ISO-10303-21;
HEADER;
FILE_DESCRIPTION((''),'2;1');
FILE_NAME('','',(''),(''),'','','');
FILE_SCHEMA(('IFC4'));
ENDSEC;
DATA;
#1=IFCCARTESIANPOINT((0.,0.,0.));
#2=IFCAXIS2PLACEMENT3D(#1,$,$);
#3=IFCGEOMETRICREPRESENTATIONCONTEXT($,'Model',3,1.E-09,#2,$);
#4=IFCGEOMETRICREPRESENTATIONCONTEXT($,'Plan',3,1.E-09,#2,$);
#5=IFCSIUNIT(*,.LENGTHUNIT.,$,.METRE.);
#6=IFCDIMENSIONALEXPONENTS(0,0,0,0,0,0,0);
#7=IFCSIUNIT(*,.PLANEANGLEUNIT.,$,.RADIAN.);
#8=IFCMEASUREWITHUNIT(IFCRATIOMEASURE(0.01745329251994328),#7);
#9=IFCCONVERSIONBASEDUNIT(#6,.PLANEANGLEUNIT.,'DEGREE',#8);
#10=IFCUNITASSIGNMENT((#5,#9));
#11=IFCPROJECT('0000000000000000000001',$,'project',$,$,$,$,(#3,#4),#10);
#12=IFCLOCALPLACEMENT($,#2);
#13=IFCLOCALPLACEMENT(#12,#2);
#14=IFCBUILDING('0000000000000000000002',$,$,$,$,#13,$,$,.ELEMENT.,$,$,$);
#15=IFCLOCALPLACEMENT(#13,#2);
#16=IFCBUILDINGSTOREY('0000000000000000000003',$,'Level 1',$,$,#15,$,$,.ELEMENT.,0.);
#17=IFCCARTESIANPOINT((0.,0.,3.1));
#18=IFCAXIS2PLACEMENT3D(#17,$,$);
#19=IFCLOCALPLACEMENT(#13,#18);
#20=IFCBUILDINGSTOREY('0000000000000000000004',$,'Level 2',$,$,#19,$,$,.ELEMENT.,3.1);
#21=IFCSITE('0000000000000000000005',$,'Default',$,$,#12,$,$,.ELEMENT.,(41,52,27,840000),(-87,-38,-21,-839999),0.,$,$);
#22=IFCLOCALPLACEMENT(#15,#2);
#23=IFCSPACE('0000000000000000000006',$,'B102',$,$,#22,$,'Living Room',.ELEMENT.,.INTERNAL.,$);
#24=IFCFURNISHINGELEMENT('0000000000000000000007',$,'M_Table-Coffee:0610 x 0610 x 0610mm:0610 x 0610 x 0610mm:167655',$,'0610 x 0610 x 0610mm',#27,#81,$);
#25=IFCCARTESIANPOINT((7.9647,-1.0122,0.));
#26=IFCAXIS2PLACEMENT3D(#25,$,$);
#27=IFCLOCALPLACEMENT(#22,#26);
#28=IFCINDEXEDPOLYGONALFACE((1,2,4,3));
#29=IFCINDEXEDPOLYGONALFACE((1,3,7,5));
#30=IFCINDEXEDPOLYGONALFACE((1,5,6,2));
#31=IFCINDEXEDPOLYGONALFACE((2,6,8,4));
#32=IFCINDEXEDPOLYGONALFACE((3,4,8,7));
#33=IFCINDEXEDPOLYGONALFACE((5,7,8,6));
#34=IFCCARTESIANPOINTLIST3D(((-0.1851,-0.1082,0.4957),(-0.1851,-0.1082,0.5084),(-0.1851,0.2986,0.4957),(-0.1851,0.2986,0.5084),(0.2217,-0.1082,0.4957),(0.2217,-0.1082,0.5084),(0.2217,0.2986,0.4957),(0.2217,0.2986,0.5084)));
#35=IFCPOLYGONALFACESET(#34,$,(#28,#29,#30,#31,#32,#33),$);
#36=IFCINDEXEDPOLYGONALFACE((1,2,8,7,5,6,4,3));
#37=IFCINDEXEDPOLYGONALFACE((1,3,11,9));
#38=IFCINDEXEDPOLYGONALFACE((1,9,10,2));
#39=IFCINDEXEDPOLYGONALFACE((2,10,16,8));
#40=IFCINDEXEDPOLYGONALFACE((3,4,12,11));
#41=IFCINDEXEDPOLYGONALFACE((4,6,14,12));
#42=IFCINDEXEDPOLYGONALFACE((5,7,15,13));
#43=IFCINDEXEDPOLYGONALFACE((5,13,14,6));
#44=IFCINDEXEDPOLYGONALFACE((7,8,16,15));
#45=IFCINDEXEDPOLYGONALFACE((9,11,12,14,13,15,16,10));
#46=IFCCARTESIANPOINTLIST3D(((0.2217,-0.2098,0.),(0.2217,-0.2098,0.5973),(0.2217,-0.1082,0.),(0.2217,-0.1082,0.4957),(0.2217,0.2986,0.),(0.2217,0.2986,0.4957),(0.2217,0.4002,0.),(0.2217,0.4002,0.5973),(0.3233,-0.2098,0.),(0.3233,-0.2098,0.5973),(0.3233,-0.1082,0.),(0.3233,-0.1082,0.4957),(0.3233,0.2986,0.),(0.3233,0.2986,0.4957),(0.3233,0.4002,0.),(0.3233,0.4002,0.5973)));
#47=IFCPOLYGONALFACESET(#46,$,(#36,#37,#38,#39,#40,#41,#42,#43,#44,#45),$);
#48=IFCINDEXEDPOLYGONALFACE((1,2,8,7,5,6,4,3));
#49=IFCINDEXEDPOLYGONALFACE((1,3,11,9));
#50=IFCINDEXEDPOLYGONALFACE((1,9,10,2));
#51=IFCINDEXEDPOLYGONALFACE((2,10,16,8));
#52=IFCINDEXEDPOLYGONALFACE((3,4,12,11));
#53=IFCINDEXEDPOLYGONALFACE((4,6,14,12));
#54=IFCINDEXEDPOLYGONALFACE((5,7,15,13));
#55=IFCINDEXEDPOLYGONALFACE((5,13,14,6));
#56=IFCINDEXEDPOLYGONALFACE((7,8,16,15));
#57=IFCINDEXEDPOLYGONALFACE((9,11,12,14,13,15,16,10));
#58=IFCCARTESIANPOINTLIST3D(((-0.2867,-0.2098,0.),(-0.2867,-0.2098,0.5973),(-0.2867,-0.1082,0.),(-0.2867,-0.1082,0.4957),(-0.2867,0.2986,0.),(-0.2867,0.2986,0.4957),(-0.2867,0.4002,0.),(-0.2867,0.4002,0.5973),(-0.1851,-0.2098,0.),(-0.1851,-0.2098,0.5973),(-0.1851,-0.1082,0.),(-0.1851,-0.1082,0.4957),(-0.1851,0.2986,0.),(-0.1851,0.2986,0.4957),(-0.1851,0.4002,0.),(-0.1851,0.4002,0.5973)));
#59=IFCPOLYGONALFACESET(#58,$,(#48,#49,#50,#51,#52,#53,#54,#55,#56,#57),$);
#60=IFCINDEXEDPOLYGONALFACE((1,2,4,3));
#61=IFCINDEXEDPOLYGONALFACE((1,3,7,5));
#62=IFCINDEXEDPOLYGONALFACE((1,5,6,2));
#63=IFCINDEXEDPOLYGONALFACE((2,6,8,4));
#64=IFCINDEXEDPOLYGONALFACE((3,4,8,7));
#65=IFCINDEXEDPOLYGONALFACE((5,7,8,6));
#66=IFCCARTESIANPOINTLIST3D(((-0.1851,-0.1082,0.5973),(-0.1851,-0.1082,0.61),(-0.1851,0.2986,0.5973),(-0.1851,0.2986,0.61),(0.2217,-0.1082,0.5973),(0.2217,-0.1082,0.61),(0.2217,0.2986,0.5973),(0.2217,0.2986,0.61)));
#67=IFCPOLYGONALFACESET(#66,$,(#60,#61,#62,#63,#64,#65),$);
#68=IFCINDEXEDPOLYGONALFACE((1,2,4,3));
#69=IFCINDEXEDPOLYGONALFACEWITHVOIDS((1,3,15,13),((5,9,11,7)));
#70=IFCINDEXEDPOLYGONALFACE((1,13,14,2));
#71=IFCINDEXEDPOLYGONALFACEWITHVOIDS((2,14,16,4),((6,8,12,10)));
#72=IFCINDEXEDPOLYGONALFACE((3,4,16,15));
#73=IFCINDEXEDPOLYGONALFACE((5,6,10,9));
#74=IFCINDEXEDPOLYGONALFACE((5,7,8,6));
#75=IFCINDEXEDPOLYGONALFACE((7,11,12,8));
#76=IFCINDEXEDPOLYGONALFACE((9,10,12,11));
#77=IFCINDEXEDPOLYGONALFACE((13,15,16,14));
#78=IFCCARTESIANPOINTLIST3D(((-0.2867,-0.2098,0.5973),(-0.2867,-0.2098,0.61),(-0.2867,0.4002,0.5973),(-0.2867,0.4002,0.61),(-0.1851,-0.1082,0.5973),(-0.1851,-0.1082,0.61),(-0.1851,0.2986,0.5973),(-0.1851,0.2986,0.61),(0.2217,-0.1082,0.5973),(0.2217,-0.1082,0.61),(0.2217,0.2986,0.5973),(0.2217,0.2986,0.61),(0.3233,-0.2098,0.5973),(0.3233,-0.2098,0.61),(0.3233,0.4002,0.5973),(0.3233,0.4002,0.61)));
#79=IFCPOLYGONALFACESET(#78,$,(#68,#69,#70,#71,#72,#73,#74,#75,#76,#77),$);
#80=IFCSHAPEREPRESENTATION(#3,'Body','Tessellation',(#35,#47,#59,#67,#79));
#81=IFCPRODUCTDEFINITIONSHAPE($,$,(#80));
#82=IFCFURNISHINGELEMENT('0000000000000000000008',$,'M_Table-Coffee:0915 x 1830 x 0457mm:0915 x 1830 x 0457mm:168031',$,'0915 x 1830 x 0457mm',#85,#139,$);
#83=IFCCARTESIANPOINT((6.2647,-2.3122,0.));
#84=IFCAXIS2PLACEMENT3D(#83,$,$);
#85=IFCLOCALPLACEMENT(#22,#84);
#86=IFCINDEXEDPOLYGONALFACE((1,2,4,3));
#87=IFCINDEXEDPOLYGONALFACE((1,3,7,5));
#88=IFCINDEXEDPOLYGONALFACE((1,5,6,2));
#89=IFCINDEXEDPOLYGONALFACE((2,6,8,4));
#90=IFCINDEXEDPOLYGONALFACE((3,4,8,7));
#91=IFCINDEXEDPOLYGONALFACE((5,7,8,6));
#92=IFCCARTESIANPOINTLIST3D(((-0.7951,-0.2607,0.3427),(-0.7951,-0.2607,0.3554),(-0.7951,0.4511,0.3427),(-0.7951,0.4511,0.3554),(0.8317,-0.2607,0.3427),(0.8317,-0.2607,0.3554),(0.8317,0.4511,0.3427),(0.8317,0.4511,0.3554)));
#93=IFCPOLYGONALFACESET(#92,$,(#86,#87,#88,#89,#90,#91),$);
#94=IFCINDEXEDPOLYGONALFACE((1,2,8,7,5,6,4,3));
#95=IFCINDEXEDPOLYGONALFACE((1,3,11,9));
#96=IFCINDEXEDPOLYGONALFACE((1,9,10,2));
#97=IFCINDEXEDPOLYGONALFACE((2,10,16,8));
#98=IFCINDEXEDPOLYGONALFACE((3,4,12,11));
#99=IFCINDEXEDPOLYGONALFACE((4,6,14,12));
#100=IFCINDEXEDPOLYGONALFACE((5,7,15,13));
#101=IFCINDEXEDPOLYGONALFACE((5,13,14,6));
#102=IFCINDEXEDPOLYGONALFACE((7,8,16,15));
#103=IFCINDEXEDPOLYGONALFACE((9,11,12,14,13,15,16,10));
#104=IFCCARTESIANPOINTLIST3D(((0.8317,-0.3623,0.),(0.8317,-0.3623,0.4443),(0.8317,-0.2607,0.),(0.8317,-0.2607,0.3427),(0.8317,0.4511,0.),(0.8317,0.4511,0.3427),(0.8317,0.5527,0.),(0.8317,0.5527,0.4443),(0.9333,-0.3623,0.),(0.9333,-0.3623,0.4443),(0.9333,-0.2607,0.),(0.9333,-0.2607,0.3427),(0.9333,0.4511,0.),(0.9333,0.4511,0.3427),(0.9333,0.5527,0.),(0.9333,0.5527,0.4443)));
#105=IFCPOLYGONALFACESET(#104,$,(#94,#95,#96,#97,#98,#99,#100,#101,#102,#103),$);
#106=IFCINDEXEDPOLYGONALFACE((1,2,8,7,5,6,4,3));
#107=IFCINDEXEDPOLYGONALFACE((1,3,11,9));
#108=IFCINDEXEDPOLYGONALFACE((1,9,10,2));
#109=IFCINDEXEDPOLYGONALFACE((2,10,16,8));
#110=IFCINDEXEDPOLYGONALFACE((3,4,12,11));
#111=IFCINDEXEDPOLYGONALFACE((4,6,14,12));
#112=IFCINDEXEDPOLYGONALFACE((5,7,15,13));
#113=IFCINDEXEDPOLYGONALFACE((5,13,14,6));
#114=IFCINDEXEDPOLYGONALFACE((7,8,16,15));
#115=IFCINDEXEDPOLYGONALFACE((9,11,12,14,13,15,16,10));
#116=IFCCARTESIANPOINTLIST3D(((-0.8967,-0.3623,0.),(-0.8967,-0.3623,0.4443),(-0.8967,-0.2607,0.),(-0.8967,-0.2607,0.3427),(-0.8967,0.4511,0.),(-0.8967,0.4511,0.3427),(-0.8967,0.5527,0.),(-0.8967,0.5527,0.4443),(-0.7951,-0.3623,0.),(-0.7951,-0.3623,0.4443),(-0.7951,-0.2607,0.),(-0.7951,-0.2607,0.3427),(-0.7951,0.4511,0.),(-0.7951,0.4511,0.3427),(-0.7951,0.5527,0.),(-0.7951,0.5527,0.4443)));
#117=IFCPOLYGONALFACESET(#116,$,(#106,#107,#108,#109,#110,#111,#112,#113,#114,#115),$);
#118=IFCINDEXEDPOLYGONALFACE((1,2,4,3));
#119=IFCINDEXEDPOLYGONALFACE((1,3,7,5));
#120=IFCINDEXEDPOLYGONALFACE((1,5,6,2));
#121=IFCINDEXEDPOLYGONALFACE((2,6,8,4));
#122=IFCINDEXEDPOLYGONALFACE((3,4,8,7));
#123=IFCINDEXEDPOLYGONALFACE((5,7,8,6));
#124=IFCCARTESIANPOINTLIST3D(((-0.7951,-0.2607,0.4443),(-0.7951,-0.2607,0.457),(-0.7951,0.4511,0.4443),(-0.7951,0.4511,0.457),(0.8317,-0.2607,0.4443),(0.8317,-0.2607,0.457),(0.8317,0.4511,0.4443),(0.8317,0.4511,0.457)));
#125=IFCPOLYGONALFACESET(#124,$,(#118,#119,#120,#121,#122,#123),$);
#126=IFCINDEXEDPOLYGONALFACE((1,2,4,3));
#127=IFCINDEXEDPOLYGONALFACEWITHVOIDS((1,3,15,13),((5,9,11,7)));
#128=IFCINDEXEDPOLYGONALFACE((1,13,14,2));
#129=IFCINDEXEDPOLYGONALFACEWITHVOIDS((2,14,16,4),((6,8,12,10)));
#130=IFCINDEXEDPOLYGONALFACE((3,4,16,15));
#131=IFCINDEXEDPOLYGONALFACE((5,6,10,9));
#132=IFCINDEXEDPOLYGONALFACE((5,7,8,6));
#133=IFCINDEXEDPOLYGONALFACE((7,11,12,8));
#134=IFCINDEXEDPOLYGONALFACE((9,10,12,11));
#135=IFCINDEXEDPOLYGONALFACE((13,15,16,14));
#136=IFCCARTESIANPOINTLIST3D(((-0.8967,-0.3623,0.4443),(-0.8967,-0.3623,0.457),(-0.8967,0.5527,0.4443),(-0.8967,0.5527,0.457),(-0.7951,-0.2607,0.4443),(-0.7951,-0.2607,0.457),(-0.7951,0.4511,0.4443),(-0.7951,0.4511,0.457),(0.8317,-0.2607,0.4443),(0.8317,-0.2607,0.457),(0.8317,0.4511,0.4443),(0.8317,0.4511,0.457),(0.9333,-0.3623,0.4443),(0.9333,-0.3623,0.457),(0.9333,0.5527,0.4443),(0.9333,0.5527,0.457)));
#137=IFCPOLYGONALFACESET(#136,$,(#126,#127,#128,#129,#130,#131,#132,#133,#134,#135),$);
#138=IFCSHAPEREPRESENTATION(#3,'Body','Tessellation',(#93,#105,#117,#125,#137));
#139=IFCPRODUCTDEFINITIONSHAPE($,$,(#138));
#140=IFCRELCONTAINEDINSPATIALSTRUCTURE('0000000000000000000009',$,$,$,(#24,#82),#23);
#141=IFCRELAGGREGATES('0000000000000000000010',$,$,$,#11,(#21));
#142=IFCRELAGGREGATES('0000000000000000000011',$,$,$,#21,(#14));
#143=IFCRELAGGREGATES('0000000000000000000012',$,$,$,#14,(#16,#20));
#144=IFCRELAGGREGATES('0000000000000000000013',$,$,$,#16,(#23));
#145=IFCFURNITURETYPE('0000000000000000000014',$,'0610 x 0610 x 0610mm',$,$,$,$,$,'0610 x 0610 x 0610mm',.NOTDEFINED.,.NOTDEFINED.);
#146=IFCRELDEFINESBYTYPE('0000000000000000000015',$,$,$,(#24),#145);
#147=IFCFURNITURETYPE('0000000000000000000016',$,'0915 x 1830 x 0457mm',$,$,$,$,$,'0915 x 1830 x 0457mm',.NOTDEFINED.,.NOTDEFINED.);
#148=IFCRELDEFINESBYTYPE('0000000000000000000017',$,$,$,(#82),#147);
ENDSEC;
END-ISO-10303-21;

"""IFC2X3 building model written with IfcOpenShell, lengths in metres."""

from ifc_helpers import new_model, entity, si_unit, converted_unit, frame, origin, origin_2d_with_axis, place, context, project, spatial, polyline, rectangle, outline, extrude, source, transform, mapped, type_object, type_shapes, element, save


model = new_model("IFC2X3")

# Units and contexts
model_context_1 = context("Model", 3, precision=1e-09, world=origin())
plan_context = context("Plan", 3, precision=1e-09, world=origin())
ifc_project = project(units=[si_unit("LENGTHUNIT", "METRE"), converted_unit("PLANEANGLEUNIT", "DEGREE", entity("IfcRatioMeasure", 0.01745329251994328), si_unit("PLANEANGLEUNIT", "RADIAN"), dimensions=[0, 0, 0, 0, 0, 0, 0])], contexts=[model_context_1, plan_context])

# Site, building, storey
site_placement = place(None, origin())
site = spatial("IfcSite", under=ifc_project, at=site_placement, Name="Default", CompositionType="ELEMENT", RefLatitude=(41, 52, 27, 840000), RefLongitude=(-87, -38, -21, -839999), RefElevation=0.0)
building_placement = place(site_placement, origin())
building = spatial("IfcBuilding", under=site, at=building_placement, CompositionType="ELEMENT")
storey_1_placement = place(building_placement, origin())
storey_1 = spatial("IfcBuildingStorey", under=building, at=storey_1_placement, Name="Level 1", CompositionType="ELEMENT", Elevation=0.0)

# Shared definitions
storey_2_placement = place(building_placement, frame((0.0, 0.0, 3.1)))
storey_2 = spatial("IfcBuildingStorey", under=building, at=storey_2_placement, Name="Level 2", CompositionType="ELEMENT", Elevation=3.1)

# Shared definitions
space_1_placement = place(storey_1_placement, origin())
space_1 = spatial("IfcSpace", under=storey_1, at=space_1_placement, Name="B102", LongName="Living Room", CompositionType="ELEMENT", InteriorOrExteriorSpace="INTERNAL")

# Furnishing elements
furniture_type_1 = type_object("IfcFurnitureType", Name="0610 x 0610 x 0610mm", ElementType="0610 x 0610 x 0610mm", AssemblyPlace="NOTDEFINED")
shared_shape_1 = source(origin(), model_context_1, "Body", "SweptSolid", [
    extrude(rectangle(XDim=0.4068, YDim=0.4068, at=origin_2d_with_axis()), frame((0.0183, 0.0952, 0.4957), z_axis=(0.0, 0.0, 1.0), x_axis=(-1.0, 0.0, 0.0)), (0.0, 0.0, 1.0), 0.0127),
    extrude(outline(polyline([(-0.2732, -0.305), (0.324, -0.305), (0.324, 0.305), (-0.2732, 0.305), (-0.2732, 0.2034), (0.2225, 0.2034), (0.2225, -0.2034), (-0.2732, -0.2034), (-0.2732, -0.305)])), frame((0.2217, 0.0952, 0.2732), z_axis=(1.0, 0.0, 0.0), x_axis=(0.0, 0.0, 1.0)), (0.0, 0.0, 1.0), 0.1016),
    extrude(outline(polyline([(-0.305, -0.3241), (0.305, -0.3241), (0.305, 0.2733), (0.2034, 0.2733), (0.2034, -0.2224), (-0.2034, -0.2224), (-0.2034, 0.2733), (-0.305, 0.2733), (-0.305, -0.3241)])), frame((-0.2867, 0.0952, 0.2733), z_axis=(1.0, 0.0, 0.0), x_axis=(0.0, -1.0, 0.0)), (0.0, 0.0, 1.0), 0.1016),
    extrude(rectangle(XDim=0.4068, YDim=0.4068, at=origin_2d_with_axis()), frame((0.0183, 0.0952, 0.5973), z_axis=(0.0, 0.0, 1.0), x_axis=(-1.0, 0.0, 0.0)), (0.0, 0.0, 1.0), 0.0127),
    extrude(outline(polyline([(-0.305, -0.305), (0.305, -0.305), (0.305, 0.305), (-0.305, 0.305), (-0.305, -0.305)]), holes=[polyline([(-0.2034, -0.2034), (-0.2034, 0.2034), (0.2034, 0.2034), (0.2034, -0.2034), (-0.2034, -0.2034)])]), frame((0.0183, 0.0952, 0.5973), z_axis=(0.0, 0.0, 1.0), x_axis=(-1.0, 0.0, 0.0)), (0.0, 0.0, 1.0), 0.0127),
])
type_shapes(furniture_type_1, [shared_shape_1])
for number, where, name in (
    (1, (7.9647, -1.0122, 0.0), "M_Table-Coffee:0610 x 0610 x 0610mm:0610 x 0610 x 0610mm:167655"),
):
    element("IfcFurnishingElement", number, at=place(space_1_placement, frame(where)), inside=space_1, type_object=furniture_type_1, Name=name, ObjectType="0610 x 0610 x 0610mm", context=model_context_1, shape_type="MappedRepresentation", body=[
        mapped(shared_shape_1, transform((0.0, 0.0, 0.0), scale=1.0)),
    ])
furniture_type_2 = type_object("IfcFurnitureType", Name="0915 x 1830 x 0457mm", ElementType="0915 x 1830 x 0457mm", AssemblyPlace="NOTDEFINED")
shared_shape_2 = source(origin(), model_context_1, "Body", "SweptSolid", [
    extrude(rectangle(XDim=1.6268, YDim=0.7118, at=origin_2d_with_axis()), frame((0.0183, 0.0952, 0.3427), z_axis=(0.0, 0.0, 1.0), x_axis=(-1.0, 0.0, 0.0)), (0.0, 0.0, 1.0), 0.0127),
    extrude(outline(polyline([(-0.1967, -0.4575), (0.2475, -0.4575), (0.2475, 0.4575), (-0.1967, 0.4575), (-0.1967, 0.3559), (0.146, 0.3559), (0.146, -0.3559), (-0.1967, -0.3559), (-0.1967, -0.4575)])), frame((0.8317, 0.0952, 0.1967), z_axis=(1.0, 0.0, 0.0), x_axis=(0.0, 0.0, 1.0)), (0.0, 0.0, 1.0), 0.1016),
    extrude(outline(polyline([(-0.4575, -0.2476), (0.4575, -0.2476), (0.4575, 0.1968), (0.3559, 0.1968), (0.3559, -0.1459), (-0.3559, -0.1459), (-0.3559, 0.1968), (-0.4575, 0.1968), (-0.4575, -0.2476)])), frame((-0.8967, 0.0952, 0.1968), z_axis=(1.0, 0.0, 0.0), x_axis=(0.0, -1.0, 0.0)), (0.0, 0.0, 1.0), 0.1016),
    extrude(rectangle(XDim=1.6268, YDim=0.7118, at=origin_2d_with_axis()), frame((0.0183, 0.0952, 0.4443), z_axis=(0.0, 0.0, 1.0), x_axis=(-1.0, 0.0, 0.0)), (0.0, 0.0, 1.0), 0.0127),
    extrude(outline(polyline([(-0.915, -0.4575), (0.915, -0.4575), (0.915, 0.4575), (-0.915, 0.4575), (-0.915, -0.4575)]), holes=[polyline([(-0.8134, -0.3559), (-0.8134, 0.3559), (0.8134, 0.3559), (0.8134, -0.3559), (-0.8134, -0.3559)])]), frame((0.0183, 0.0952, 0.4443), z_axis=(0.0, 0.0, 1.0), x_axis=(-1.0, 0.0, 0.0)), (0.0, 0.0, 1.0), 0.0127),
])
type_shapes(furniture_type_2, [shared_shape_2])
furnishing_1_placement = place(space_1_placement, frame((6.2647, -2.3122, 0.0)))
element("IfcFurnishingElement", 2, at=furnishing_1_placement, inside=space_1, type_object=furniture_type_2, Name="M_Table-Coffee:0915 x 1830 x 0457mm:0915 x 1830 x 0457mm:168031", ObjectType="0915 x 1830 x 0457mm", context=model_context_1, shape_type="MappedRepresentation", body=[
    mapped(shared_shape_2, transform((0.0, 0.0, 0.0), scale=1.0)),
])

save(model, "model.ifc")
